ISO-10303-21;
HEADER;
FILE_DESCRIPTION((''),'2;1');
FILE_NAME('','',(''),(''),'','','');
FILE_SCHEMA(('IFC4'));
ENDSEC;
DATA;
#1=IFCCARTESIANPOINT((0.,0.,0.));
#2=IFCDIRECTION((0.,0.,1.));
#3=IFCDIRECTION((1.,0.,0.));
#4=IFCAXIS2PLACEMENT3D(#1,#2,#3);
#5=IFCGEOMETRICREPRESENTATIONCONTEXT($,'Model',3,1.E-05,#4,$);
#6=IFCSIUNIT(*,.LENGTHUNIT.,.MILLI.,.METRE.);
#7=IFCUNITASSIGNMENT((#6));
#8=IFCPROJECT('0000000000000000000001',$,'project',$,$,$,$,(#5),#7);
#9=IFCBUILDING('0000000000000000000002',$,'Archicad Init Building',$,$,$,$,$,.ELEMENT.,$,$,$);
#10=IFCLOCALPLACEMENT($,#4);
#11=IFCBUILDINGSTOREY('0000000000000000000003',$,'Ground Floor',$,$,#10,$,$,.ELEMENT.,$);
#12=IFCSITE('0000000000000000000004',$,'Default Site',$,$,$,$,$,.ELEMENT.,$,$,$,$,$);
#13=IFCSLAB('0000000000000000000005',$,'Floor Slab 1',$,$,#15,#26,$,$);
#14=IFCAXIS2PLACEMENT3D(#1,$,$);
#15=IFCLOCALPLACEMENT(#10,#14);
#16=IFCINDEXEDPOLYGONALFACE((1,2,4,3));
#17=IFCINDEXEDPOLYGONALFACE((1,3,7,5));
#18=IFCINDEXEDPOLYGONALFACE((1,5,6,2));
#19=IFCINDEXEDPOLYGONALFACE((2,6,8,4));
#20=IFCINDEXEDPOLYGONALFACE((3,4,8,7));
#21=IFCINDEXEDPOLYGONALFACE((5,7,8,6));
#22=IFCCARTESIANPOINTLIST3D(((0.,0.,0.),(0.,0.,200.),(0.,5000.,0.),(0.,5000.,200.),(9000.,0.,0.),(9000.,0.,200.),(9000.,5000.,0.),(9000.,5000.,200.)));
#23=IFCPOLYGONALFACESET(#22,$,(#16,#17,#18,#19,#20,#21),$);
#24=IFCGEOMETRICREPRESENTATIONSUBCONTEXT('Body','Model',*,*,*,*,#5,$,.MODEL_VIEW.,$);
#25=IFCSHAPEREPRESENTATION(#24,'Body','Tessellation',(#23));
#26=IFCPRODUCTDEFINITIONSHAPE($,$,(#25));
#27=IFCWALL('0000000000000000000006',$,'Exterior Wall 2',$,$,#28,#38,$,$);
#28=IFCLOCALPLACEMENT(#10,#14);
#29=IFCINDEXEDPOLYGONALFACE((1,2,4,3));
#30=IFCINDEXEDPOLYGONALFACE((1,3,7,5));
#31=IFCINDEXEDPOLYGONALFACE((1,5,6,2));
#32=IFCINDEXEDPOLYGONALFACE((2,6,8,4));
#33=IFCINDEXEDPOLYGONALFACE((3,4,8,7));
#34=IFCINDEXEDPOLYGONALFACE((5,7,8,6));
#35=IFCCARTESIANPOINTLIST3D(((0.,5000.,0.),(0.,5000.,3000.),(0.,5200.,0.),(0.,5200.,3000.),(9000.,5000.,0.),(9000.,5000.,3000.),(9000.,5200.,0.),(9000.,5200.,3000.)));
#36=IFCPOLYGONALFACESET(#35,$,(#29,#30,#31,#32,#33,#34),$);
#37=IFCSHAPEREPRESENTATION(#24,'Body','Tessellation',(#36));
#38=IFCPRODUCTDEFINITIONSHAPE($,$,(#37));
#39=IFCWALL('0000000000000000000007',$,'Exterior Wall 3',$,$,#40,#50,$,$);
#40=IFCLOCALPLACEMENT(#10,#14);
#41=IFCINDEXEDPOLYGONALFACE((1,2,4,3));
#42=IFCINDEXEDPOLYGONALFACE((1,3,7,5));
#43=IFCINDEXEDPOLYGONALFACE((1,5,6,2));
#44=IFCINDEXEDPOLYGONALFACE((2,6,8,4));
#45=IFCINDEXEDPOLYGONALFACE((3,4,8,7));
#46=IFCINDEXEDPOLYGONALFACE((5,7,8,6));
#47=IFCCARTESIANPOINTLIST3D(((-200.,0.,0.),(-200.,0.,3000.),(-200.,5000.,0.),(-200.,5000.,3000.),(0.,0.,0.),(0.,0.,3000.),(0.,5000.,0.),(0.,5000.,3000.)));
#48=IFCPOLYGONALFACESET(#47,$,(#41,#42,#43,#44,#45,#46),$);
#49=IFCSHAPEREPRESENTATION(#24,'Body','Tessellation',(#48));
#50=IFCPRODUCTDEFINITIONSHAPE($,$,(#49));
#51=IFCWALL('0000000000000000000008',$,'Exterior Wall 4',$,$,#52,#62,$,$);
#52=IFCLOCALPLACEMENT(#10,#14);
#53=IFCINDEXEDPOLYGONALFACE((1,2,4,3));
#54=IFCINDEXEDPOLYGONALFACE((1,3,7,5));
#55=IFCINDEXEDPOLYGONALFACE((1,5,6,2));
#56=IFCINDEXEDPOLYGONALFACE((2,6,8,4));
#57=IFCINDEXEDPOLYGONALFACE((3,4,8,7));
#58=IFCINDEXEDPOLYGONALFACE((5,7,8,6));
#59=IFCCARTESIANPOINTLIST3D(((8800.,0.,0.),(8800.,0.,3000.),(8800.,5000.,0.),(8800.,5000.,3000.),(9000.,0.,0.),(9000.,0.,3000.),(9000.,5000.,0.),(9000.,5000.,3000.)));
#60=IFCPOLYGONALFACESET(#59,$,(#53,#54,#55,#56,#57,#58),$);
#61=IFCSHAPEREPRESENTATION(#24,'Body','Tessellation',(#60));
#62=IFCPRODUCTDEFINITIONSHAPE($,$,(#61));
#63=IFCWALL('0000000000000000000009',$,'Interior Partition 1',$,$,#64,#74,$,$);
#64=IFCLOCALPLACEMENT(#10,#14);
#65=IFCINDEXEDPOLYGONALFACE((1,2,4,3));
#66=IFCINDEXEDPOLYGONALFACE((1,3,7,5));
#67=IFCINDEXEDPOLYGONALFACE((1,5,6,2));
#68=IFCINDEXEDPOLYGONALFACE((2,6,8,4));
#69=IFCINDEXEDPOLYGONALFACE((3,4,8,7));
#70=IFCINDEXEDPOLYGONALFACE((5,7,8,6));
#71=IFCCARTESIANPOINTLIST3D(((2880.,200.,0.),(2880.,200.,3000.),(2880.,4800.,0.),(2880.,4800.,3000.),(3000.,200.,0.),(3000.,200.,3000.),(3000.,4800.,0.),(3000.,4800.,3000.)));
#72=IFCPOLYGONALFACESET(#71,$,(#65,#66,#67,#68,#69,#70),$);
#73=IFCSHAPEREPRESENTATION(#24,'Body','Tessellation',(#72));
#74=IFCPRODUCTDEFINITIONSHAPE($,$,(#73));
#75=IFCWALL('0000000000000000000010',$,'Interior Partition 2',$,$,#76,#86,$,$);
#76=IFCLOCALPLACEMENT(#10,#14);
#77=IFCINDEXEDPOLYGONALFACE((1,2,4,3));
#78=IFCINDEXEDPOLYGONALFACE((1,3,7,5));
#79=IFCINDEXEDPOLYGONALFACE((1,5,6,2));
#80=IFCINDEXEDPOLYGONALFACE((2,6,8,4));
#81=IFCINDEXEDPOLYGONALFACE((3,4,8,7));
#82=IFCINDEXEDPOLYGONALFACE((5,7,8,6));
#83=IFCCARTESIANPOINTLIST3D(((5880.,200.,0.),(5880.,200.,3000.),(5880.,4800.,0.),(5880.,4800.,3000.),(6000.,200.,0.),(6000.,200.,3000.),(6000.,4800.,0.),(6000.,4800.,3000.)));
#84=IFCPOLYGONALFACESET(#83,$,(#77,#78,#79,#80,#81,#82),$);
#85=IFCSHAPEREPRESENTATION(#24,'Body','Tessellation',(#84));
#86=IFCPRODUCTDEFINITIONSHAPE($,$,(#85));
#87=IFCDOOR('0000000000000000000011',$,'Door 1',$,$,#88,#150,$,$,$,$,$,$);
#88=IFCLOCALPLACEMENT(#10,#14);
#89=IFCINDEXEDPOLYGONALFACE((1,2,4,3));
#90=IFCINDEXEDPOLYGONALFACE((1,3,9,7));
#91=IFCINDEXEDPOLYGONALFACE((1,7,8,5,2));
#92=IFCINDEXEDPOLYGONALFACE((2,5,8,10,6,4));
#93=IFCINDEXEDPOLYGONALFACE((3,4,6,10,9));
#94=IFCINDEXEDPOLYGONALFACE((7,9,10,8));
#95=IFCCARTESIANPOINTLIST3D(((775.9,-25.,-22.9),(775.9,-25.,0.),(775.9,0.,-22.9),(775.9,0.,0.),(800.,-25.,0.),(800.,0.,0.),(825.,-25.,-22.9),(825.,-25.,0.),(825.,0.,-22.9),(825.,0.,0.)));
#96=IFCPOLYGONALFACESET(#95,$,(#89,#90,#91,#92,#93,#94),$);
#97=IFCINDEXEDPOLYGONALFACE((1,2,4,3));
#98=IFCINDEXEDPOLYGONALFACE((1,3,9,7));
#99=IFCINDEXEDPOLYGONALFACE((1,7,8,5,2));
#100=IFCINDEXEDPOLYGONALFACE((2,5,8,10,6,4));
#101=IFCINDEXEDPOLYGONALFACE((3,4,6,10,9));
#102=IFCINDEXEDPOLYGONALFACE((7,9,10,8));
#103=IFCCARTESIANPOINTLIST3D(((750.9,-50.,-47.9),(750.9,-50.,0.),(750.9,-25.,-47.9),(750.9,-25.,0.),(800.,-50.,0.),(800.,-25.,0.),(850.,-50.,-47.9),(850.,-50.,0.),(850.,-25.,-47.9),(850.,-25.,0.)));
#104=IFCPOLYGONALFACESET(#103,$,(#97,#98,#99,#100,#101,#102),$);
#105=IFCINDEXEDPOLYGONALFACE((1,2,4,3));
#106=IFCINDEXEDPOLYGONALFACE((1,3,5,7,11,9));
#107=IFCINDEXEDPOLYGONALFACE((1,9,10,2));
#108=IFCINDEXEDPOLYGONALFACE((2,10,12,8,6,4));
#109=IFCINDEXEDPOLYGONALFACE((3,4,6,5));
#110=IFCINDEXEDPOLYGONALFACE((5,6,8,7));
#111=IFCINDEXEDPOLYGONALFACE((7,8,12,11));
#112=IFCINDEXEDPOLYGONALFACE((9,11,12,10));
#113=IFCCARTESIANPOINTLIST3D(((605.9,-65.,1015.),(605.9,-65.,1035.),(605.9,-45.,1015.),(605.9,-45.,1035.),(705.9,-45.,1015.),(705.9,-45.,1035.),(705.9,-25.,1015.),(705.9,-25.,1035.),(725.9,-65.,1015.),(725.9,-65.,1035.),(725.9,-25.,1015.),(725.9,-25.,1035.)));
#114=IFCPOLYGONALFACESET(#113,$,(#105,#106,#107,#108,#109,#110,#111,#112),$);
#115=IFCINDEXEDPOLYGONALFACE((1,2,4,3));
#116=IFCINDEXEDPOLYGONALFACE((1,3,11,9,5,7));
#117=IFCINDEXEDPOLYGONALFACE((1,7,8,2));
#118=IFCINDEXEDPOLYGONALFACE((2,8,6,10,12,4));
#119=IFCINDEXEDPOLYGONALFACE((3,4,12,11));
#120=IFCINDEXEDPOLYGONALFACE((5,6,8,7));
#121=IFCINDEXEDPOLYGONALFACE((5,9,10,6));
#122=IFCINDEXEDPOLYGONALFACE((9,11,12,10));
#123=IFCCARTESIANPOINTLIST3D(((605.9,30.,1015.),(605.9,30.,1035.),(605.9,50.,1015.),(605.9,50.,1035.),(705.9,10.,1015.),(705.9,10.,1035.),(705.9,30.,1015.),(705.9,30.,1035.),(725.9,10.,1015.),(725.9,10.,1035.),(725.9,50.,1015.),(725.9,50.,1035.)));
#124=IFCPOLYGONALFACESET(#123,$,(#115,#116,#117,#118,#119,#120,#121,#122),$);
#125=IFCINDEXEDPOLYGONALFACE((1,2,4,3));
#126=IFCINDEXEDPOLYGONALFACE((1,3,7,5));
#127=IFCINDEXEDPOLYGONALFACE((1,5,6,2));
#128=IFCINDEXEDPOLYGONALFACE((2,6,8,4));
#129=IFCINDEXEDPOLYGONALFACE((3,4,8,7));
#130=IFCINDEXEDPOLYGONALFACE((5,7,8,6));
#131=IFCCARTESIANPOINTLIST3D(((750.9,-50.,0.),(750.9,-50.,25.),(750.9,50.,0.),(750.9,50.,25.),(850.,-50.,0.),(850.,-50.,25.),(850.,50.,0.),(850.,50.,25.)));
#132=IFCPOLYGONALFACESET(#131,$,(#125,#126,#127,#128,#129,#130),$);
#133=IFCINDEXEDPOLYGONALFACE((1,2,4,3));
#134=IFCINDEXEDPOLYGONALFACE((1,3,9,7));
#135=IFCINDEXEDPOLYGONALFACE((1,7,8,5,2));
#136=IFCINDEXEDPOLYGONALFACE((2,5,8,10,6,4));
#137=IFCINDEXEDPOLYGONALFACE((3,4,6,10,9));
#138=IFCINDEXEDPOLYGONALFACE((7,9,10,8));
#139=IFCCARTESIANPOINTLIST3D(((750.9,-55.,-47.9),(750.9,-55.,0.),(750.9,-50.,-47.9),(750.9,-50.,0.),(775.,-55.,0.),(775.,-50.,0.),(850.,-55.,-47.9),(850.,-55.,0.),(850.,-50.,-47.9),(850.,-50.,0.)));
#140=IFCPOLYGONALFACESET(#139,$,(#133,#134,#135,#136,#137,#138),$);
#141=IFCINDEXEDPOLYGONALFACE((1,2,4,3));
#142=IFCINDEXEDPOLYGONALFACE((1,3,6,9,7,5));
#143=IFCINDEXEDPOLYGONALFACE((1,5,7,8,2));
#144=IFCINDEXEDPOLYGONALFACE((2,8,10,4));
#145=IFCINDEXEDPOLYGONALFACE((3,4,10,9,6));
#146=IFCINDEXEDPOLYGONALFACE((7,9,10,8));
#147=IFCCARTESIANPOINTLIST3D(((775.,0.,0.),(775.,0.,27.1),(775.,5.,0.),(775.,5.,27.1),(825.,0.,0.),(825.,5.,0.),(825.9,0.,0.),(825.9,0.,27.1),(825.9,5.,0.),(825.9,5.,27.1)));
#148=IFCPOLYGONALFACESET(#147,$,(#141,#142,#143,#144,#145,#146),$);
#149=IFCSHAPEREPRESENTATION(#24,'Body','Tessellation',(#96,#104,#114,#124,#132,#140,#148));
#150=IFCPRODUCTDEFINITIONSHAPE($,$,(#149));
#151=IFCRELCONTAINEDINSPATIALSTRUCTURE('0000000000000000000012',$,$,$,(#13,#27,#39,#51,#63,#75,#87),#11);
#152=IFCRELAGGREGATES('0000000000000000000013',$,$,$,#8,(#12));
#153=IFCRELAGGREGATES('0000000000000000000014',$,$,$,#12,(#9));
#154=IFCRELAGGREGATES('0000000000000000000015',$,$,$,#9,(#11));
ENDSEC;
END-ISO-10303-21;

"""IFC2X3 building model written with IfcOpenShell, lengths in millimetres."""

from ifc_helpers import new_model, si_unit, frame, origin_with_axes, place, context, subcontext, project, spatial, polyline, outline, extrude, element, save


model = new_model("IFC2X3")

# Units and contexts
model_context = context("Model", 3, precision=1e-05, world=origin_with_axes())
body_context = subcontext(model_context, "Body", "Model", "MODEL_VIEW")
ifc_project = project(units=[si_unit("LENGTHUNIT", "METRE", prefix="MILLI")], contexts=[model_context])

# Site, building, storey
site = spatial("IfcSite", under=ifc_project, Name="Default Site", CompositionType="ELEMENT")
building = spatial("IfcBuilding", under=site, Name="Archicad Init Building", CompositionType="ELEMENT")
storey_placement = place(None, origin_with_axes())
storey = spatial("IfcBuildingStorey", under=building, at=storey_placement, Name="Ground Floor", CompositionType="ELEMENT")

# Slab
slab_placement = place(storey_placement, origin_with_axes())
element("IfcSlab", 1, at=slab_placement, inside=storey, Name="Floor Slab 1", context=body_context, shape_type="SweptSolid", body=[
    extrude(outline(polyline([(0.0, 0.0), (9000.0, 0.0), (9000.0, 5000.0), (0.0, 5000.0), (0.0, 0.0)])), origin_with_axes(), (0.0, 0.0, 1.0), 200.0),
])

# Walls
wall_placement = place(storey_placement, frame((0.0, 5000.0, 0.0), z_axis=(0.0, 0.0, 1.0), x_axis=(1.0, 0.0, 0.0)))
element("IfcWall", 2, at=wall_placement, inside=storey, Name="Exterior Wall 2", context=body_context, shape_type="SweptSolid", body=[
    extrude(outline(polyline([(0.0, 0.0), (0.0, 200.0), (9000.0, 200.0), (9000.0, 0.0), (0.0, 0.0)])), origin_with_axes(), (0.0, 0.0, 1.0), 3000.0),
])
for number, where, z_axis, x_axis, name in (
    (3, (0.0, 0.0, 0.0), (0.0, 0.0, 1.0), (0.0, 1.0, 0.0), "Exterior Wall 3"),
    (4, (9000.0, 0.0, 0.0), (0.0, 0.0, 1.0), (0.0, 1.0, 0.0), "Exterior Wall 4"),
):
    element("IfcWall", number, at=place(storey_placement, frame(where, z_axis=z_axis, x_axis=x_axis)), inside=storey, Name=name, context=body_context, shape_type="SweptSolid", body=[
        extrude(outline(polyline([(0.0, 0.0), (0.0, 200.0), (5000.0, 200.0), (5000.0, 0.0), (0.0, 0.0)])), origin_with_axes(), (0.0, 0.0, 1.0), 3000.0),
    ])
for number, where, z_axis, x_axis, name in (
    (5, (3000.0, 200.0, 0.0), (0.0, 0.0, 1.0), (0.0, 1.0, 0.0), "Interior Partition 1"),
    (6, (6000.0, 200.0, 0.0), (0.0, 0.0, 1.0), (0.0, 1.0, 0.0), "Interior Partition 2"),
):
    element("IfcWall", number, at=place(storey_placement, frame(where, z_axis=z_axis, x_axis=x_axis)), inside=storey, Name=name, context=body_context, shape_type="SweptSolid", body=[
        extrude(outline(polyline([(0.0, 0.0), (0.0, 120.0), (4600.0, 120.0), (4600.0, 0.0), (0.0, 0.0)])), origin_with_axes(), (0.0, 0.0, 1.0), 3000.0),
    ])

# Door
door_1_placement = place(storey_placement, frame((800.0, -50.0, 0.0), z_axis=(0.0, 0.0, 1.0), x_axis=(1.0, 0.0, 0.0)))
element("IfcDoor", 7, at=door_1_placement, inside=storey, Name="Door 1", context=body_context, shape_type="SweptSolid", body=[
    extrude(outline(polyline([(0.0, 0.0), (0.0, 2.1), (0.9, 2.1), (0.9, 0.0), (-24.1, 0.0), (-24.1, -22.9), (25.0, -22.9), (25.0, 0.0), (0.0, 0.0)])), frame((0.0, 25.0, 0.0), z_axis=(0.0, -1.0, 0.0), x_axis=(1.0, 0.0, 0.0)), (0.0, 0.0, -1.0), 25.0),
    extrude(outline(polyline([(0.0, 0.0), (0.0, 2.1), (0.9, 2.1), (0.9, 0.0), (-49.1, 0.0), (-49.1, -47.9), (50.0, -47.9), (50.0, 0.0), (0.0, 0.0)])), frame((0.0, 0.0, 0.0), z_axis=(0.0, -1.0, 0.0), x_axis=(1.0, 0.0, 0.0)), (0.0, 0.0, -1.0), 25.0),
    extrude(outline(polyline([(0.0, 0.0), (-49.1, 0.0), (-49.1, 35.0), (0.0, 35.0), (0.0, 0.0)])), frame((25.0, 25.0, 25.0), z_axis=(0.0, 0.0, 1.0), x_axis=(1.0, 0.0, 0.0)), (0.0, 0.0, 1.0), -47.9),
    extrude(outline(polyline([(0.0, 0.0), (0.0, -40.0), (-120.0, -40.0), (-120.0, -20.0), (-20.0, -20.0), (-20.0, 0.0), (0.0, 0.0)])), frame((-74.1, 25.0, 1015.0), z_axis=(0.0, 0.0, 1.0), x_axis=(1.0, 0.0, 0.0)), (0.0, 0.0, 1.0), 20.0),
    extrude(outline(polyline([(0.0, 0.0), (0.0, 40.0), (-120.0, 40.0), (-120.0, 20.0), (-20.0, 20.0), (-20.0, 0.0), (0.0, 0.0)])), frame((-74.1, 60.0, 1015.0), z_axis=(0.0, 0.0, 1.0), x_axis=(1.0, 0.0, 0.0)), (0.0, 0.0, 1.0), 20.0),
    extrude(outline(polyline([(0.0, 0.0), (-99.1, 0.0), (-99.1, 100.0), (0.0, 100.0), (0.0, 0.0)])), frame((50.0, 0.0, 0.0), z_axis=(0.0, 0.0, 1.0), x_axis=(1.0, 0.0, 0.0)), (0.0, 0.0, 1.0), 25.0),
    extrude(outline(polyline([(0.0, 0.0), (0.0, 27.1), (50.9, 27.1), (50.9, 0.0), (-24.1, 0.0), (-24.1, -47.9), (75.0, -47.9), (75.0, 0.0), (0.0, 0.0)])), frame((-25.0, -5.0, 0.0), z_axis=(0.0, -1.0, 0.0), x_axis=(1.0, 0.0, 0.0)), (0.0, 0.0, -1.0), 5.0),
    extrude(outline(polyline([(0.0, 0.0), (0.0, 27.1), (50.9, 27.1), (50.9, 0.0), (0.9, 0.0), (0.9, -22.9), (50.0, -22.9), (50.0, 0.0), (0.0, 0.0)])), frame((-25.0, 50.0, 0.0), z_axis=(0.0, -1.0, 0.0), x_axis=(1.0, 0.0, 0.0)), (0.0, 0.0, -1.0), 5.0),
])

save(model, "model.ifc")
